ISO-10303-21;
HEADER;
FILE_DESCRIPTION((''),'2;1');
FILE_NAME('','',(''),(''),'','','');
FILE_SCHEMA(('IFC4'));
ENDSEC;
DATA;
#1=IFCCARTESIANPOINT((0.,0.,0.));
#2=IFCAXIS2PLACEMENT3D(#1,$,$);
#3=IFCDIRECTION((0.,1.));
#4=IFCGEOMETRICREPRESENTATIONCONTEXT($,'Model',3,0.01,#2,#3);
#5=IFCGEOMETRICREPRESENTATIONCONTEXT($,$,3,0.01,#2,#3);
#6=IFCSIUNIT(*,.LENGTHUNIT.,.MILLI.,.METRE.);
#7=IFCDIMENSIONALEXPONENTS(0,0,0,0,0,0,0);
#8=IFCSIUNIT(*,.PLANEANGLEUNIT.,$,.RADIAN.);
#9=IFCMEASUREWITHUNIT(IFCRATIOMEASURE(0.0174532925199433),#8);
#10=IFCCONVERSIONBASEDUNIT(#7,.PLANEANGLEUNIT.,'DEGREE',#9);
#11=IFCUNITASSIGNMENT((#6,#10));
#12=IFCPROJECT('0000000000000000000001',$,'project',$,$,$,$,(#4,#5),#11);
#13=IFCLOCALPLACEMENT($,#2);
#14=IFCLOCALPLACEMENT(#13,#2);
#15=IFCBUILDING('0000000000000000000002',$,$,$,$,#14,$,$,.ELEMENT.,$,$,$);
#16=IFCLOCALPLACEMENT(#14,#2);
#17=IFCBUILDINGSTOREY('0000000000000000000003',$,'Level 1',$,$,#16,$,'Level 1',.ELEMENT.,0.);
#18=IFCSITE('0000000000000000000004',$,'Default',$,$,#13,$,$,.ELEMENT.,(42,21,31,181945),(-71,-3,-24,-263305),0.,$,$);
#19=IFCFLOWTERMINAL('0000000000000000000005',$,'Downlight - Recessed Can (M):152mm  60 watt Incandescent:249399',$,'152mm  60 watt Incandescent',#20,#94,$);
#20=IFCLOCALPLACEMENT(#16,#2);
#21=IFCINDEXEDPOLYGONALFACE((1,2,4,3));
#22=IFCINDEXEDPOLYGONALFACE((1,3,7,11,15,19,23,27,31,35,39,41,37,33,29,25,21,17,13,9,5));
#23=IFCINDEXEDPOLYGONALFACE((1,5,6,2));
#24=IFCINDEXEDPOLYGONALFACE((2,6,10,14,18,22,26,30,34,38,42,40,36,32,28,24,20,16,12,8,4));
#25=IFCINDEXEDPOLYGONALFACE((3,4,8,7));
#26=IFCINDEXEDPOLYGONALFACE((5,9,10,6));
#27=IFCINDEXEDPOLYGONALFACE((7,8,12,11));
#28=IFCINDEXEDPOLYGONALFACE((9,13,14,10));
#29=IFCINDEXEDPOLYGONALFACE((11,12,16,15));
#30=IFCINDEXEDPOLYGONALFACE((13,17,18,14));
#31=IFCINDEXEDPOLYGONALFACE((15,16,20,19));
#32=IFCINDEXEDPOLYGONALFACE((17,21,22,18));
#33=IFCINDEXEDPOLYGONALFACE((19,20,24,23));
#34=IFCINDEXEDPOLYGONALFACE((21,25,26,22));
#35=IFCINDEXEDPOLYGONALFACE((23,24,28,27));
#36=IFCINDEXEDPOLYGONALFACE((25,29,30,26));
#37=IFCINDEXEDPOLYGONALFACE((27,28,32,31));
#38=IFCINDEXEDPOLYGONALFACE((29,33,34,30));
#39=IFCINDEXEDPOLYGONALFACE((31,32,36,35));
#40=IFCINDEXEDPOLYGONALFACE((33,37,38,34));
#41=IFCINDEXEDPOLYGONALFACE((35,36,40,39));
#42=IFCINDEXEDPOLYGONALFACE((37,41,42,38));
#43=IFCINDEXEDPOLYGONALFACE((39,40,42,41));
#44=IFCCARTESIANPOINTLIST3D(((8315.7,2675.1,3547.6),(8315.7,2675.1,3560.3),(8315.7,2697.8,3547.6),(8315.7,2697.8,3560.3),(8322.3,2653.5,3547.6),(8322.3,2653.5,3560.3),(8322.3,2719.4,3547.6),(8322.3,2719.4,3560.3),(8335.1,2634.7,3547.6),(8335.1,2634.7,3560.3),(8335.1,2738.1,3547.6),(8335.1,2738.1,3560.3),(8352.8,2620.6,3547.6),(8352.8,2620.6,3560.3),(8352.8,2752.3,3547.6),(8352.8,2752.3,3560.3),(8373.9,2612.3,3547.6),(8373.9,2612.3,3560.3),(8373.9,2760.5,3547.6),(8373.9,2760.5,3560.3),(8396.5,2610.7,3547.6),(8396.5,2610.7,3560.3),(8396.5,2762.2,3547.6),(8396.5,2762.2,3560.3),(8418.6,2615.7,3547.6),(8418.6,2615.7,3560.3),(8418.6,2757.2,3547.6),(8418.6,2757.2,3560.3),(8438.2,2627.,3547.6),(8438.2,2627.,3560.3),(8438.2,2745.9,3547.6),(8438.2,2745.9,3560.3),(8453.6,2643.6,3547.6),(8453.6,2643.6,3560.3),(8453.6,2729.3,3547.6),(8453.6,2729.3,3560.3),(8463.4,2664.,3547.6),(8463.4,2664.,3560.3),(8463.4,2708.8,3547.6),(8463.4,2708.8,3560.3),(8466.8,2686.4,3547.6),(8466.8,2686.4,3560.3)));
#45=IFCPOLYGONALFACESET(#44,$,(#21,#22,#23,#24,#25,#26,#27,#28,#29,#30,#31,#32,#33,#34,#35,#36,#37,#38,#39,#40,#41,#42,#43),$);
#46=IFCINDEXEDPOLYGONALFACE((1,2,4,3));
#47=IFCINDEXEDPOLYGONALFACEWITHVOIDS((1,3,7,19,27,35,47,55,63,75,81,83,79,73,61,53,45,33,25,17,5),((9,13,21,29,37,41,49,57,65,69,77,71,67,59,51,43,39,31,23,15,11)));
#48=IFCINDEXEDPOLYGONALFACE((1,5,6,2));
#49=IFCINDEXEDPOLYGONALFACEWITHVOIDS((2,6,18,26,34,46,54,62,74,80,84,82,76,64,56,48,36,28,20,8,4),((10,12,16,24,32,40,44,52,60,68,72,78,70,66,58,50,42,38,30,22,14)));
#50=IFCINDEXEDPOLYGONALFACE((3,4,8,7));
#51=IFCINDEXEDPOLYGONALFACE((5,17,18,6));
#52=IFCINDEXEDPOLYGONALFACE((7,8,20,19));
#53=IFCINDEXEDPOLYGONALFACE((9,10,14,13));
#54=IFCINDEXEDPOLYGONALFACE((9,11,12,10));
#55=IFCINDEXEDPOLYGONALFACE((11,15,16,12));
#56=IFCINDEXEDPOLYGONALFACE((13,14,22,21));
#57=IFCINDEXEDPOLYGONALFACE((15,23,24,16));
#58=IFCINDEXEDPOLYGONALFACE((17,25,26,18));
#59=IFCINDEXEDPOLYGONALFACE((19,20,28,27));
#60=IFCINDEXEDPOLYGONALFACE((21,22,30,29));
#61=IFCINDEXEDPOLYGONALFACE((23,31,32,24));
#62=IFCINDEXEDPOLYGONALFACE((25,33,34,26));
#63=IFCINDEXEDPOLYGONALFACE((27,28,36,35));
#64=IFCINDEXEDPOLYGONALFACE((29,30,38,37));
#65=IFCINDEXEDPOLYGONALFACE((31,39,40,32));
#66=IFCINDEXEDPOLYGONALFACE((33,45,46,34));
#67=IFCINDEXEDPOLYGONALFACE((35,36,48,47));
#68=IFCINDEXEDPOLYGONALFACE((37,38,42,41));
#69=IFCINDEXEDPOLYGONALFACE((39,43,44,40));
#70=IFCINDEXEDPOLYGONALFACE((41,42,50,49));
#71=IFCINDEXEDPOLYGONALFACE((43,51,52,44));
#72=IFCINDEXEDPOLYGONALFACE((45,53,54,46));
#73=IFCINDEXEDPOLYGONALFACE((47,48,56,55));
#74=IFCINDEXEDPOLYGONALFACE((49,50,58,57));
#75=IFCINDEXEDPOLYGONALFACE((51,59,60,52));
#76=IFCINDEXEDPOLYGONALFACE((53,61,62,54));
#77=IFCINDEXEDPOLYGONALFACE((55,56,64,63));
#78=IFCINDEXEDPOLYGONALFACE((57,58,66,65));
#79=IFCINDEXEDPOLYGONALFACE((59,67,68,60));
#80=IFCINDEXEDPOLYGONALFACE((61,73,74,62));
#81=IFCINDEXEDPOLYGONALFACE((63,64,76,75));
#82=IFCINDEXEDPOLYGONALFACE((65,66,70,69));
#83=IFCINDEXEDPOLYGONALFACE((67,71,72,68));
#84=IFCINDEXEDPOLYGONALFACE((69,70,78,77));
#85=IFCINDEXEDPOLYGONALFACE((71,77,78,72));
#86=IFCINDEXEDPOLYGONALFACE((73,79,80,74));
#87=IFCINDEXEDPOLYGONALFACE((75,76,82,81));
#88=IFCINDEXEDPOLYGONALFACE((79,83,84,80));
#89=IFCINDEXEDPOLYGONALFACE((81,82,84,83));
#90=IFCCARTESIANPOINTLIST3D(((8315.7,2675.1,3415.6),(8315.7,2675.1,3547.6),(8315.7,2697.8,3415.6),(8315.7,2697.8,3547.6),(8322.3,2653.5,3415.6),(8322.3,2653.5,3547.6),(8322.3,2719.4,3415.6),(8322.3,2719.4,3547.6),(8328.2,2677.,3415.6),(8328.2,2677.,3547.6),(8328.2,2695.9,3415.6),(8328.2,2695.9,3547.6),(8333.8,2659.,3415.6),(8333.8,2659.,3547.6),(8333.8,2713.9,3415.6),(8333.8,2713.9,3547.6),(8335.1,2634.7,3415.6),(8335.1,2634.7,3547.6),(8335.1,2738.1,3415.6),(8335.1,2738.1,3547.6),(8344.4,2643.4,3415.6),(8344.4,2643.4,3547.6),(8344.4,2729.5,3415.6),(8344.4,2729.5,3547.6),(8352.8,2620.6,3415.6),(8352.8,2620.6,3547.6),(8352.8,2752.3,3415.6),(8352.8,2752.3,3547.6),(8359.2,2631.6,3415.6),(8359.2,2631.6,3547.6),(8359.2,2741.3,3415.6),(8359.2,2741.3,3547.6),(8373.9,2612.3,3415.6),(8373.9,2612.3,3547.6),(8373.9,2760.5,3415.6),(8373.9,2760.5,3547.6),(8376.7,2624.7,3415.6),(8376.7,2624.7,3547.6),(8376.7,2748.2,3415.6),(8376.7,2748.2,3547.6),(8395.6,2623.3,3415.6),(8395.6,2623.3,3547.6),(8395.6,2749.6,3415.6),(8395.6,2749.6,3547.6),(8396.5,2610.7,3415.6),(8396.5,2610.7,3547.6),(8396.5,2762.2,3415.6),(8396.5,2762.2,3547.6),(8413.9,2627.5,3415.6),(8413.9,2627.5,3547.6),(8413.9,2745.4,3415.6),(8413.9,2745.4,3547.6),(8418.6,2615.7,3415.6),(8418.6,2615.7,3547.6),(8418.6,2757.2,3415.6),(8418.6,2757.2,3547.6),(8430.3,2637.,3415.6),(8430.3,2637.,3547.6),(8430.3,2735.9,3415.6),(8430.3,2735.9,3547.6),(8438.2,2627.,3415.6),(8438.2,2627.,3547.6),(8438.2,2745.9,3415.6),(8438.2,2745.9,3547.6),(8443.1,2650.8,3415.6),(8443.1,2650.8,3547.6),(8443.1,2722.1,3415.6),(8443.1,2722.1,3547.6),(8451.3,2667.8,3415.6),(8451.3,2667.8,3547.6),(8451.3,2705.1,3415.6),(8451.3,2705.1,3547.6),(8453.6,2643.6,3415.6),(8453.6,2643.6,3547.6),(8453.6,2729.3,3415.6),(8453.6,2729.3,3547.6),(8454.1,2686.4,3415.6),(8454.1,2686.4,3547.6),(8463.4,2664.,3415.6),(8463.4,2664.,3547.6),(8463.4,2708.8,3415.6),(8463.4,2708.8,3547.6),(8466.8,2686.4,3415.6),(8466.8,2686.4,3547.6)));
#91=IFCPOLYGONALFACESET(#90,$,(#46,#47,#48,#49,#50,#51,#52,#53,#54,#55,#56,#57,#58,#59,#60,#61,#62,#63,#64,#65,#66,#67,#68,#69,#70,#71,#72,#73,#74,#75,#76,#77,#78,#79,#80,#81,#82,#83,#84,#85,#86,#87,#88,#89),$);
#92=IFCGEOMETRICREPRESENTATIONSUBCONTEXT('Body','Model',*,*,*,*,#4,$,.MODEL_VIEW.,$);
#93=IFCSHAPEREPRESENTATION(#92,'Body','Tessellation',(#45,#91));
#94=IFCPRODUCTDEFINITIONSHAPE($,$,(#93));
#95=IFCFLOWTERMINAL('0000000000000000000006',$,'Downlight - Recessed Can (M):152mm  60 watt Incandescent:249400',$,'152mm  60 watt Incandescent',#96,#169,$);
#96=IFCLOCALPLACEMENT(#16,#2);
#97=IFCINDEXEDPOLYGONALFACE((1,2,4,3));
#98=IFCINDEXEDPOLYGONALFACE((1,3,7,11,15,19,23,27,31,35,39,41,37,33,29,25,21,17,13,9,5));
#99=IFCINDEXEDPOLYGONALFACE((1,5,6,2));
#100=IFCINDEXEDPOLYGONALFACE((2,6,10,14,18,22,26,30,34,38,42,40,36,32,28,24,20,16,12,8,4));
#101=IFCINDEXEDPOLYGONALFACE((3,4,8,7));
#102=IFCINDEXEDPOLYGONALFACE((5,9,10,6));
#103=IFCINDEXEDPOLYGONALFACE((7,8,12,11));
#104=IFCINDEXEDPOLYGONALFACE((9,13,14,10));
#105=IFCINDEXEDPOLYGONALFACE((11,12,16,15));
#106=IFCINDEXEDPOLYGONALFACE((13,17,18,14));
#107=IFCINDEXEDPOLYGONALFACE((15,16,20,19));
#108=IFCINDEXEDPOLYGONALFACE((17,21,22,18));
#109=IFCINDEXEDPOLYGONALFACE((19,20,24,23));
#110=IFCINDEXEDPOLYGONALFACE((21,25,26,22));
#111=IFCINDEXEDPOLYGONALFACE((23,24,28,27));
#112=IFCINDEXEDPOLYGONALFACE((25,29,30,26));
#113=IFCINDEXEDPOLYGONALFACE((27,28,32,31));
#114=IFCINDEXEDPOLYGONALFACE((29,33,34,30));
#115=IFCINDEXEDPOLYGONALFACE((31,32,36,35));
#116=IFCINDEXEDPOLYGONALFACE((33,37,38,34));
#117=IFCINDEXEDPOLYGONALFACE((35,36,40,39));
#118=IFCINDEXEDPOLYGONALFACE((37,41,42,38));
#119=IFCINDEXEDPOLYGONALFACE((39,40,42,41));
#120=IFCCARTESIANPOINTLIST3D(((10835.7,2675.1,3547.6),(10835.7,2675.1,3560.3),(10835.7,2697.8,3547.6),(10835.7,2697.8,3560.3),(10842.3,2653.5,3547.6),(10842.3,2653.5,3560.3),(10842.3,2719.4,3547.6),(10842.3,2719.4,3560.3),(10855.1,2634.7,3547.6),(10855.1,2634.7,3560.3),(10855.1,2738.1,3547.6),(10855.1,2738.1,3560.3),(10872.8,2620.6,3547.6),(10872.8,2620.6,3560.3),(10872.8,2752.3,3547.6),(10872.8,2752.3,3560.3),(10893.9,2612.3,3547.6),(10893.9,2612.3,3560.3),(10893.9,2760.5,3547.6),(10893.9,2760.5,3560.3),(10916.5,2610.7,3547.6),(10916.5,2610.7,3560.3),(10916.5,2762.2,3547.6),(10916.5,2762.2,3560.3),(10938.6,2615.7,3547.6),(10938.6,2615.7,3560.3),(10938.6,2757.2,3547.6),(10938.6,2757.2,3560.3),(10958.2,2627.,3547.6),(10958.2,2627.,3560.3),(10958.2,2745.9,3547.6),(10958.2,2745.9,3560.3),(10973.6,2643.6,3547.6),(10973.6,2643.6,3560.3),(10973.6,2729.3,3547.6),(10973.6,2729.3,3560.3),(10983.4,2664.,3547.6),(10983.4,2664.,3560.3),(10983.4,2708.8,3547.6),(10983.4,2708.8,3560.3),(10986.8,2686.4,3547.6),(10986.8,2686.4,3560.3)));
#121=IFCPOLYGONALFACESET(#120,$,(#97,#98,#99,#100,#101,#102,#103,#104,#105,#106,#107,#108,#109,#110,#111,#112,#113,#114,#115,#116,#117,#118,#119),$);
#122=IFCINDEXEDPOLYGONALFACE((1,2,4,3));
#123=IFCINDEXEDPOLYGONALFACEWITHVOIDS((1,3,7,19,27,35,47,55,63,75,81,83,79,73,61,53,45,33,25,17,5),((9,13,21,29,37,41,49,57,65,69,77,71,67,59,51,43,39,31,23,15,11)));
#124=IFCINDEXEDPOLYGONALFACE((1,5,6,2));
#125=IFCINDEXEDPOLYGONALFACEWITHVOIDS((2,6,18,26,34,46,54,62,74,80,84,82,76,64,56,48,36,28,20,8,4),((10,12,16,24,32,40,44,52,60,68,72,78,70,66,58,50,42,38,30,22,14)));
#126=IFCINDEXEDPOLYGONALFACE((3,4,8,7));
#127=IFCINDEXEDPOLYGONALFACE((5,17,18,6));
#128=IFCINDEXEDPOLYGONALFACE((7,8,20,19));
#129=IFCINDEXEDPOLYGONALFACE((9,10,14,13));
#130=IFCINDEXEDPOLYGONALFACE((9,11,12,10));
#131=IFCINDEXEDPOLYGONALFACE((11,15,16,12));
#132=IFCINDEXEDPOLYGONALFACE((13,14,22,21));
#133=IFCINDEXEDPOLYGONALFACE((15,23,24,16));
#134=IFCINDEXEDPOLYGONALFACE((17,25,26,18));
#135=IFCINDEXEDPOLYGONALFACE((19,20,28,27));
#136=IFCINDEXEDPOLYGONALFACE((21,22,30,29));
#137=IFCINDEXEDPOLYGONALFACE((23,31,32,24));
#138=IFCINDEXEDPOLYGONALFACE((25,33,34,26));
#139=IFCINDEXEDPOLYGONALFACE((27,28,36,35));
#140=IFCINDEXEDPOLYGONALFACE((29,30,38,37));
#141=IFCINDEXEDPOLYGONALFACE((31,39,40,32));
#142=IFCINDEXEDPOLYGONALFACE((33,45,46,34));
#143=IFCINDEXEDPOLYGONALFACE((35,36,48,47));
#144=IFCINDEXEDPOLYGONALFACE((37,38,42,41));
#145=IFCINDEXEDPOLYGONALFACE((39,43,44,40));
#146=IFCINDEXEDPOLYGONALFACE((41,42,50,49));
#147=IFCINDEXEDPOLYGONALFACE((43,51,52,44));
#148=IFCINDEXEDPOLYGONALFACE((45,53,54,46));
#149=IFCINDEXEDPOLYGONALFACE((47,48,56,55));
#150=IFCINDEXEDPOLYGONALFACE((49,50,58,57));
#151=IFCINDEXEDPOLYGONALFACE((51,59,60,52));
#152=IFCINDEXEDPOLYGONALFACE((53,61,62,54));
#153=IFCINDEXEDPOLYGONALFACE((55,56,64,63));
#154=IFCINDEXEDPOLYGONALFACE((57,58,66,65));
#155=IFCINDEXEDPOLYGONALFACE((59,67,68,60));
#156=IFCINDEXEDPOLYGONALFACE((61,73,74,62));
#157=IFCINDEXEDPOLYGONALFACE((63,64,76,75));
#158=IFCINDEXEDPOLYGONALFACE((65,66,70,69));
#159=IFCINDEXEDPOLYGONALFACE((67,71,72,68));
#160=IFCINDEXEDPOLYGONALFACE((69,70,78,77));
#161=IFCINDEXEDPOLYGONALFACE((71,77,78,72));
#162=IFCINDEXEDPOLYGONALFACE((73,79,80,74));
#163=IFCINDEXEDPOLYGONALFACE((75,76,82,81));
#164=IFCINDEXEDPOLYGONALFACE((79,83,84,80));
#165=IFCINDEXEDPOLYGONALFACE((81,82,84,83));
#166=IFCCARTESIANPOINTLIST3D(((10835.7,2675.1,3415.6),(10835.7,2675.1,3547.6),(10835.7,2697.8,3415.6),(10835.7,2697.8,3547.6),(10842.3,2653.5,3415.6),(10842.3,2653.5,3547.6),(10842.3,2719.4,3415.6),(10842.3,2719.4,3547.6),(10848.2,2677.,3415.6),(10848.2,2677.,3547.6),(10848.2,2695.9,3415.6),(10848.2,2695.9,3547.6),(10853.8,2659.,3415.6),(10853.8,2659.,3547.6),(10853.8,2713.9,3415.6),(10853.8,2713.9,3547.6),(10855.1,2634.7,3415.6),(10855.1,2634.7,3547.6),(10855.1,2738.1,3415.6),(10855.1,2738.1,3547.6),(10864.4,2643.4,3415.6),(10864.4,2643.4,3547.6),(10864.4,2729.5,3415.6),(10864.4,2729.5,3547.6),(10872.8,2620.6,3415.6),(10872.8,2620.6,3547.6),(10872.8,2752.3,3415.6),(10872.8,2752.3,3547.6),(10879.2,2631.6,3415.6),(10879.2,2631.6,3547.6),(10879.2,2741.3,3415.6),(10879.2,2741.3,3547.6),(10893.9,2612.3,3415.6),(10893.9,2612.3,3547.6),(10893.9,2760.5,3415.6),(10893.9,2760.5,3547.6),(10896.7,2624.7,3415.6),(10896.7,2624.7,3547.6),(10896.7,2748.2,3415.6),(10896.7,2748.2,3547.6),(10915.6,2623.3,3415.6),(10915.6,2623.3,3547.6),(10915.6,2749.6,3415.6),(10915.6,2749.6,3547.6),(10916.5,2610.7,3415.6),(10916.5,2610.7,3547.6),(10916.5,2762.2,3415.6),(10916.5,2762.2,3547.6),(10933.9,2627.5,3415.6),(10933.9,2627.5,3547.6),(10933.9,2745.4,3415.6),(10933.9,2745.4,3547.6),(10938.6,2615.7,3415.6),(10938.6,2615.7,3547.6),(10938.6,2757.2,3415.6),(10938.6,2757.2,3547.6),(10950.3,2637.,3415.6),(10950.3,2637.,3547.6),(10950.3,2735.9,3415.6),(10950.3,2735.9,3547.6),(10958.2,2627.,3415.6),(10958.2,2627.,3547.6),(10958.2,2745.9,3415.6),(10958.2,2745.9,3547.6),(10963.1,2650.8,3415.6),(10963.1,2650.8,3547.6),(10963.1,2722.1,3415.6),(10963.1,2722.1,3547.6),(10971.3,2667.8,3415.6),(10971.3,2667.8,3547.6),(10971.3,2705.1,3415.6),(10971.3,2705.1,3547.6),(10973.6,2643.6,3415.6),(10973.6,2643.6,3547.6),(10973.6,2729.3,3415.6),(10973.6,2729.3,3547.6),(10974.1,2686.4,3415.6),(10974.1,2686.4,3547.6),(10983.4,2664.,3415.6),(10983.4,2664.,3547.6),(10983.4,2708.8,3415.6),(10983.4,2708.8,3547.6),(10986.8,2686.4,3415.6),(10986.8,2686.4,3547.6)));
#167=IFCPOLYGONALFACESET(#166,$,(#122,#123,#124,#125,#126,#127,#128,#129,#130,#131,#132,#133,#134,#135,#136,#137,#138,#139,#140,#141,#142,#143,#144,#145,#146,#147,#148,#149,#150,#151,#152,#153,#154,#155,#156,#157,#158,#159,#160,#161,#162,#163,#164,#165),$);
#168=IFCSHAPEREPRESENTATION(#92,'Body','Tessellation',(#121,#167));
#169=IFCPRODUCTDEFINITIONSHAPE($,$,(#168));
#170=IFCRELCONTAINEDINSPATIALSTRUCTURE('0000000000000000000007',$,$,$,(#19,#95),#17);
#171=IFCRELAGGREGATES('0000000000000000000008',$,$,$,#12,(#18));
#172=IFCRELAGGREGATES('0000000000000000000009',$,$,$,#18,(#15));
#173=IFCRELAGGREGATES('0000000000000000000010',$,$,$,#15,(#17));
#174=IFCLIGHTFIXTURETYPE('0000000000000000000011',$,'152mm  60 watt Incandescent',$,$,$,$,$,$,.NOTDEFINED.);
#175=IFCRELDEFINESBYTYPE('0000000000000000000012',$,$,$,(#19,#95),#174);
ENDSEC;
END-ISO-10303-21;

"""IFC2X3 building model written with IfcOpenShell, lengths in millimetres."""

from ifc_helpers import new_model, entity, si_unit, converted_unit, direction, frame, frame_2d, origin, place, context, subcontext, project, spatial, circle, hollow_circle, extrude, source, transform, mapped, type_object, type_shapes, element, save


model = new_model("IFC2X3")

# Units and contexts
model_context = context("Model", 3, precision=0.01, world=origin(), true_north=direction((0.0, 1.0)))
context_of_model = context(None, 3, precision=0.01, world=origin(), true_north=direction((0.0, 1.0)))
body_context = subcontext(model_context, "Body", "Model", "MODEL_VIEW")
ifc_project = project(units=[si_unit("LENGTHUNIT", "METRE", prefix="MILLI"), converted_unit("PLANEANGLEUNIT", "DEGREE", entity("IfcRatioMeasure", 0.0174532925199433), si_unit("PLANEANGLEUNIT", "RADIAN"), dimensions=[0, 0, 0, 0, 0, 0, 0])], contexts=[model_context, context_of_model])

# Site, building, storey
site_placement = place(None, origin())
site = spatial("IfcSite", under=ifc_project, at=site_placement, Name="Default", CompositionType="ELEMENT", RefLatitude=(42, 21, 31, 181945), RefLongitude=(-71, -3, -24, -263305), RefElevation=0.0)
building_placement = place(site_placement, origin())
building = spatial("IfcBuilding", under=site, at=building_placement, CompositionType="ELEMENT")
storey_placement = place(building_placement, origin())
storey = spatial("IfcBuildingStorey", under=building, at=storey_placement, Name="Level 1", LongName="Level 1", CompositionType="ELEMENT", Elevation=0.0)

# Flow terminals
light_fixture_type_1 = type_object("IfcLightFixtureType", Name="152mm  60 watt Incandescent", PredefinedType="NOTDEFINED")
shared_shape_1 = source(origin(), body_context, "Body", "SweptSolid", [
    extrude(circle(Radius=76.0, at=frame_2d((0.0, 0.0), x_axis=(1.0, 0.0))), frame((0.0, 0.0, 2628.7)), (0.0, 0.0, 1.0), 12.7),
    extrude(hollow_circle(Radius=76.0, WallThickness=12.7, at=frame_2d((0.0, 0.0), x_axis=(1.0, 0.0))), frame((0.0, 0.0, 2496.7)), (0.0, 0.0, 1.0), 132.0),
])
type_shapes(light_fixture_type_1, [shared_shape_1])
for number, where, name in (
    (1, (8390.8, 2686.4, 918.9), "Downlight - Recessed Can (M):152mm  60 watt Incandescent:249399"),
    (2, (10910.8, 2686.4, 918.9), "Downlight - Recessed Can (M):152mm  60 watt Incandescent:249400"),
):
    element("IfcFlowTerminal", number, at=place(storey_placement, frame(where)), inside=storey, type_object=light_fixture_type_1, Name=name, ObjectType="152mm  60 watt Incandescent", context=body_context, shape_type="MappedRepresentation", body=[
        mapped(shared_shape_1, transform((0.0, 0.0, 0.0), scale=1.0)),
    ])

save(model, "model.ifc")
